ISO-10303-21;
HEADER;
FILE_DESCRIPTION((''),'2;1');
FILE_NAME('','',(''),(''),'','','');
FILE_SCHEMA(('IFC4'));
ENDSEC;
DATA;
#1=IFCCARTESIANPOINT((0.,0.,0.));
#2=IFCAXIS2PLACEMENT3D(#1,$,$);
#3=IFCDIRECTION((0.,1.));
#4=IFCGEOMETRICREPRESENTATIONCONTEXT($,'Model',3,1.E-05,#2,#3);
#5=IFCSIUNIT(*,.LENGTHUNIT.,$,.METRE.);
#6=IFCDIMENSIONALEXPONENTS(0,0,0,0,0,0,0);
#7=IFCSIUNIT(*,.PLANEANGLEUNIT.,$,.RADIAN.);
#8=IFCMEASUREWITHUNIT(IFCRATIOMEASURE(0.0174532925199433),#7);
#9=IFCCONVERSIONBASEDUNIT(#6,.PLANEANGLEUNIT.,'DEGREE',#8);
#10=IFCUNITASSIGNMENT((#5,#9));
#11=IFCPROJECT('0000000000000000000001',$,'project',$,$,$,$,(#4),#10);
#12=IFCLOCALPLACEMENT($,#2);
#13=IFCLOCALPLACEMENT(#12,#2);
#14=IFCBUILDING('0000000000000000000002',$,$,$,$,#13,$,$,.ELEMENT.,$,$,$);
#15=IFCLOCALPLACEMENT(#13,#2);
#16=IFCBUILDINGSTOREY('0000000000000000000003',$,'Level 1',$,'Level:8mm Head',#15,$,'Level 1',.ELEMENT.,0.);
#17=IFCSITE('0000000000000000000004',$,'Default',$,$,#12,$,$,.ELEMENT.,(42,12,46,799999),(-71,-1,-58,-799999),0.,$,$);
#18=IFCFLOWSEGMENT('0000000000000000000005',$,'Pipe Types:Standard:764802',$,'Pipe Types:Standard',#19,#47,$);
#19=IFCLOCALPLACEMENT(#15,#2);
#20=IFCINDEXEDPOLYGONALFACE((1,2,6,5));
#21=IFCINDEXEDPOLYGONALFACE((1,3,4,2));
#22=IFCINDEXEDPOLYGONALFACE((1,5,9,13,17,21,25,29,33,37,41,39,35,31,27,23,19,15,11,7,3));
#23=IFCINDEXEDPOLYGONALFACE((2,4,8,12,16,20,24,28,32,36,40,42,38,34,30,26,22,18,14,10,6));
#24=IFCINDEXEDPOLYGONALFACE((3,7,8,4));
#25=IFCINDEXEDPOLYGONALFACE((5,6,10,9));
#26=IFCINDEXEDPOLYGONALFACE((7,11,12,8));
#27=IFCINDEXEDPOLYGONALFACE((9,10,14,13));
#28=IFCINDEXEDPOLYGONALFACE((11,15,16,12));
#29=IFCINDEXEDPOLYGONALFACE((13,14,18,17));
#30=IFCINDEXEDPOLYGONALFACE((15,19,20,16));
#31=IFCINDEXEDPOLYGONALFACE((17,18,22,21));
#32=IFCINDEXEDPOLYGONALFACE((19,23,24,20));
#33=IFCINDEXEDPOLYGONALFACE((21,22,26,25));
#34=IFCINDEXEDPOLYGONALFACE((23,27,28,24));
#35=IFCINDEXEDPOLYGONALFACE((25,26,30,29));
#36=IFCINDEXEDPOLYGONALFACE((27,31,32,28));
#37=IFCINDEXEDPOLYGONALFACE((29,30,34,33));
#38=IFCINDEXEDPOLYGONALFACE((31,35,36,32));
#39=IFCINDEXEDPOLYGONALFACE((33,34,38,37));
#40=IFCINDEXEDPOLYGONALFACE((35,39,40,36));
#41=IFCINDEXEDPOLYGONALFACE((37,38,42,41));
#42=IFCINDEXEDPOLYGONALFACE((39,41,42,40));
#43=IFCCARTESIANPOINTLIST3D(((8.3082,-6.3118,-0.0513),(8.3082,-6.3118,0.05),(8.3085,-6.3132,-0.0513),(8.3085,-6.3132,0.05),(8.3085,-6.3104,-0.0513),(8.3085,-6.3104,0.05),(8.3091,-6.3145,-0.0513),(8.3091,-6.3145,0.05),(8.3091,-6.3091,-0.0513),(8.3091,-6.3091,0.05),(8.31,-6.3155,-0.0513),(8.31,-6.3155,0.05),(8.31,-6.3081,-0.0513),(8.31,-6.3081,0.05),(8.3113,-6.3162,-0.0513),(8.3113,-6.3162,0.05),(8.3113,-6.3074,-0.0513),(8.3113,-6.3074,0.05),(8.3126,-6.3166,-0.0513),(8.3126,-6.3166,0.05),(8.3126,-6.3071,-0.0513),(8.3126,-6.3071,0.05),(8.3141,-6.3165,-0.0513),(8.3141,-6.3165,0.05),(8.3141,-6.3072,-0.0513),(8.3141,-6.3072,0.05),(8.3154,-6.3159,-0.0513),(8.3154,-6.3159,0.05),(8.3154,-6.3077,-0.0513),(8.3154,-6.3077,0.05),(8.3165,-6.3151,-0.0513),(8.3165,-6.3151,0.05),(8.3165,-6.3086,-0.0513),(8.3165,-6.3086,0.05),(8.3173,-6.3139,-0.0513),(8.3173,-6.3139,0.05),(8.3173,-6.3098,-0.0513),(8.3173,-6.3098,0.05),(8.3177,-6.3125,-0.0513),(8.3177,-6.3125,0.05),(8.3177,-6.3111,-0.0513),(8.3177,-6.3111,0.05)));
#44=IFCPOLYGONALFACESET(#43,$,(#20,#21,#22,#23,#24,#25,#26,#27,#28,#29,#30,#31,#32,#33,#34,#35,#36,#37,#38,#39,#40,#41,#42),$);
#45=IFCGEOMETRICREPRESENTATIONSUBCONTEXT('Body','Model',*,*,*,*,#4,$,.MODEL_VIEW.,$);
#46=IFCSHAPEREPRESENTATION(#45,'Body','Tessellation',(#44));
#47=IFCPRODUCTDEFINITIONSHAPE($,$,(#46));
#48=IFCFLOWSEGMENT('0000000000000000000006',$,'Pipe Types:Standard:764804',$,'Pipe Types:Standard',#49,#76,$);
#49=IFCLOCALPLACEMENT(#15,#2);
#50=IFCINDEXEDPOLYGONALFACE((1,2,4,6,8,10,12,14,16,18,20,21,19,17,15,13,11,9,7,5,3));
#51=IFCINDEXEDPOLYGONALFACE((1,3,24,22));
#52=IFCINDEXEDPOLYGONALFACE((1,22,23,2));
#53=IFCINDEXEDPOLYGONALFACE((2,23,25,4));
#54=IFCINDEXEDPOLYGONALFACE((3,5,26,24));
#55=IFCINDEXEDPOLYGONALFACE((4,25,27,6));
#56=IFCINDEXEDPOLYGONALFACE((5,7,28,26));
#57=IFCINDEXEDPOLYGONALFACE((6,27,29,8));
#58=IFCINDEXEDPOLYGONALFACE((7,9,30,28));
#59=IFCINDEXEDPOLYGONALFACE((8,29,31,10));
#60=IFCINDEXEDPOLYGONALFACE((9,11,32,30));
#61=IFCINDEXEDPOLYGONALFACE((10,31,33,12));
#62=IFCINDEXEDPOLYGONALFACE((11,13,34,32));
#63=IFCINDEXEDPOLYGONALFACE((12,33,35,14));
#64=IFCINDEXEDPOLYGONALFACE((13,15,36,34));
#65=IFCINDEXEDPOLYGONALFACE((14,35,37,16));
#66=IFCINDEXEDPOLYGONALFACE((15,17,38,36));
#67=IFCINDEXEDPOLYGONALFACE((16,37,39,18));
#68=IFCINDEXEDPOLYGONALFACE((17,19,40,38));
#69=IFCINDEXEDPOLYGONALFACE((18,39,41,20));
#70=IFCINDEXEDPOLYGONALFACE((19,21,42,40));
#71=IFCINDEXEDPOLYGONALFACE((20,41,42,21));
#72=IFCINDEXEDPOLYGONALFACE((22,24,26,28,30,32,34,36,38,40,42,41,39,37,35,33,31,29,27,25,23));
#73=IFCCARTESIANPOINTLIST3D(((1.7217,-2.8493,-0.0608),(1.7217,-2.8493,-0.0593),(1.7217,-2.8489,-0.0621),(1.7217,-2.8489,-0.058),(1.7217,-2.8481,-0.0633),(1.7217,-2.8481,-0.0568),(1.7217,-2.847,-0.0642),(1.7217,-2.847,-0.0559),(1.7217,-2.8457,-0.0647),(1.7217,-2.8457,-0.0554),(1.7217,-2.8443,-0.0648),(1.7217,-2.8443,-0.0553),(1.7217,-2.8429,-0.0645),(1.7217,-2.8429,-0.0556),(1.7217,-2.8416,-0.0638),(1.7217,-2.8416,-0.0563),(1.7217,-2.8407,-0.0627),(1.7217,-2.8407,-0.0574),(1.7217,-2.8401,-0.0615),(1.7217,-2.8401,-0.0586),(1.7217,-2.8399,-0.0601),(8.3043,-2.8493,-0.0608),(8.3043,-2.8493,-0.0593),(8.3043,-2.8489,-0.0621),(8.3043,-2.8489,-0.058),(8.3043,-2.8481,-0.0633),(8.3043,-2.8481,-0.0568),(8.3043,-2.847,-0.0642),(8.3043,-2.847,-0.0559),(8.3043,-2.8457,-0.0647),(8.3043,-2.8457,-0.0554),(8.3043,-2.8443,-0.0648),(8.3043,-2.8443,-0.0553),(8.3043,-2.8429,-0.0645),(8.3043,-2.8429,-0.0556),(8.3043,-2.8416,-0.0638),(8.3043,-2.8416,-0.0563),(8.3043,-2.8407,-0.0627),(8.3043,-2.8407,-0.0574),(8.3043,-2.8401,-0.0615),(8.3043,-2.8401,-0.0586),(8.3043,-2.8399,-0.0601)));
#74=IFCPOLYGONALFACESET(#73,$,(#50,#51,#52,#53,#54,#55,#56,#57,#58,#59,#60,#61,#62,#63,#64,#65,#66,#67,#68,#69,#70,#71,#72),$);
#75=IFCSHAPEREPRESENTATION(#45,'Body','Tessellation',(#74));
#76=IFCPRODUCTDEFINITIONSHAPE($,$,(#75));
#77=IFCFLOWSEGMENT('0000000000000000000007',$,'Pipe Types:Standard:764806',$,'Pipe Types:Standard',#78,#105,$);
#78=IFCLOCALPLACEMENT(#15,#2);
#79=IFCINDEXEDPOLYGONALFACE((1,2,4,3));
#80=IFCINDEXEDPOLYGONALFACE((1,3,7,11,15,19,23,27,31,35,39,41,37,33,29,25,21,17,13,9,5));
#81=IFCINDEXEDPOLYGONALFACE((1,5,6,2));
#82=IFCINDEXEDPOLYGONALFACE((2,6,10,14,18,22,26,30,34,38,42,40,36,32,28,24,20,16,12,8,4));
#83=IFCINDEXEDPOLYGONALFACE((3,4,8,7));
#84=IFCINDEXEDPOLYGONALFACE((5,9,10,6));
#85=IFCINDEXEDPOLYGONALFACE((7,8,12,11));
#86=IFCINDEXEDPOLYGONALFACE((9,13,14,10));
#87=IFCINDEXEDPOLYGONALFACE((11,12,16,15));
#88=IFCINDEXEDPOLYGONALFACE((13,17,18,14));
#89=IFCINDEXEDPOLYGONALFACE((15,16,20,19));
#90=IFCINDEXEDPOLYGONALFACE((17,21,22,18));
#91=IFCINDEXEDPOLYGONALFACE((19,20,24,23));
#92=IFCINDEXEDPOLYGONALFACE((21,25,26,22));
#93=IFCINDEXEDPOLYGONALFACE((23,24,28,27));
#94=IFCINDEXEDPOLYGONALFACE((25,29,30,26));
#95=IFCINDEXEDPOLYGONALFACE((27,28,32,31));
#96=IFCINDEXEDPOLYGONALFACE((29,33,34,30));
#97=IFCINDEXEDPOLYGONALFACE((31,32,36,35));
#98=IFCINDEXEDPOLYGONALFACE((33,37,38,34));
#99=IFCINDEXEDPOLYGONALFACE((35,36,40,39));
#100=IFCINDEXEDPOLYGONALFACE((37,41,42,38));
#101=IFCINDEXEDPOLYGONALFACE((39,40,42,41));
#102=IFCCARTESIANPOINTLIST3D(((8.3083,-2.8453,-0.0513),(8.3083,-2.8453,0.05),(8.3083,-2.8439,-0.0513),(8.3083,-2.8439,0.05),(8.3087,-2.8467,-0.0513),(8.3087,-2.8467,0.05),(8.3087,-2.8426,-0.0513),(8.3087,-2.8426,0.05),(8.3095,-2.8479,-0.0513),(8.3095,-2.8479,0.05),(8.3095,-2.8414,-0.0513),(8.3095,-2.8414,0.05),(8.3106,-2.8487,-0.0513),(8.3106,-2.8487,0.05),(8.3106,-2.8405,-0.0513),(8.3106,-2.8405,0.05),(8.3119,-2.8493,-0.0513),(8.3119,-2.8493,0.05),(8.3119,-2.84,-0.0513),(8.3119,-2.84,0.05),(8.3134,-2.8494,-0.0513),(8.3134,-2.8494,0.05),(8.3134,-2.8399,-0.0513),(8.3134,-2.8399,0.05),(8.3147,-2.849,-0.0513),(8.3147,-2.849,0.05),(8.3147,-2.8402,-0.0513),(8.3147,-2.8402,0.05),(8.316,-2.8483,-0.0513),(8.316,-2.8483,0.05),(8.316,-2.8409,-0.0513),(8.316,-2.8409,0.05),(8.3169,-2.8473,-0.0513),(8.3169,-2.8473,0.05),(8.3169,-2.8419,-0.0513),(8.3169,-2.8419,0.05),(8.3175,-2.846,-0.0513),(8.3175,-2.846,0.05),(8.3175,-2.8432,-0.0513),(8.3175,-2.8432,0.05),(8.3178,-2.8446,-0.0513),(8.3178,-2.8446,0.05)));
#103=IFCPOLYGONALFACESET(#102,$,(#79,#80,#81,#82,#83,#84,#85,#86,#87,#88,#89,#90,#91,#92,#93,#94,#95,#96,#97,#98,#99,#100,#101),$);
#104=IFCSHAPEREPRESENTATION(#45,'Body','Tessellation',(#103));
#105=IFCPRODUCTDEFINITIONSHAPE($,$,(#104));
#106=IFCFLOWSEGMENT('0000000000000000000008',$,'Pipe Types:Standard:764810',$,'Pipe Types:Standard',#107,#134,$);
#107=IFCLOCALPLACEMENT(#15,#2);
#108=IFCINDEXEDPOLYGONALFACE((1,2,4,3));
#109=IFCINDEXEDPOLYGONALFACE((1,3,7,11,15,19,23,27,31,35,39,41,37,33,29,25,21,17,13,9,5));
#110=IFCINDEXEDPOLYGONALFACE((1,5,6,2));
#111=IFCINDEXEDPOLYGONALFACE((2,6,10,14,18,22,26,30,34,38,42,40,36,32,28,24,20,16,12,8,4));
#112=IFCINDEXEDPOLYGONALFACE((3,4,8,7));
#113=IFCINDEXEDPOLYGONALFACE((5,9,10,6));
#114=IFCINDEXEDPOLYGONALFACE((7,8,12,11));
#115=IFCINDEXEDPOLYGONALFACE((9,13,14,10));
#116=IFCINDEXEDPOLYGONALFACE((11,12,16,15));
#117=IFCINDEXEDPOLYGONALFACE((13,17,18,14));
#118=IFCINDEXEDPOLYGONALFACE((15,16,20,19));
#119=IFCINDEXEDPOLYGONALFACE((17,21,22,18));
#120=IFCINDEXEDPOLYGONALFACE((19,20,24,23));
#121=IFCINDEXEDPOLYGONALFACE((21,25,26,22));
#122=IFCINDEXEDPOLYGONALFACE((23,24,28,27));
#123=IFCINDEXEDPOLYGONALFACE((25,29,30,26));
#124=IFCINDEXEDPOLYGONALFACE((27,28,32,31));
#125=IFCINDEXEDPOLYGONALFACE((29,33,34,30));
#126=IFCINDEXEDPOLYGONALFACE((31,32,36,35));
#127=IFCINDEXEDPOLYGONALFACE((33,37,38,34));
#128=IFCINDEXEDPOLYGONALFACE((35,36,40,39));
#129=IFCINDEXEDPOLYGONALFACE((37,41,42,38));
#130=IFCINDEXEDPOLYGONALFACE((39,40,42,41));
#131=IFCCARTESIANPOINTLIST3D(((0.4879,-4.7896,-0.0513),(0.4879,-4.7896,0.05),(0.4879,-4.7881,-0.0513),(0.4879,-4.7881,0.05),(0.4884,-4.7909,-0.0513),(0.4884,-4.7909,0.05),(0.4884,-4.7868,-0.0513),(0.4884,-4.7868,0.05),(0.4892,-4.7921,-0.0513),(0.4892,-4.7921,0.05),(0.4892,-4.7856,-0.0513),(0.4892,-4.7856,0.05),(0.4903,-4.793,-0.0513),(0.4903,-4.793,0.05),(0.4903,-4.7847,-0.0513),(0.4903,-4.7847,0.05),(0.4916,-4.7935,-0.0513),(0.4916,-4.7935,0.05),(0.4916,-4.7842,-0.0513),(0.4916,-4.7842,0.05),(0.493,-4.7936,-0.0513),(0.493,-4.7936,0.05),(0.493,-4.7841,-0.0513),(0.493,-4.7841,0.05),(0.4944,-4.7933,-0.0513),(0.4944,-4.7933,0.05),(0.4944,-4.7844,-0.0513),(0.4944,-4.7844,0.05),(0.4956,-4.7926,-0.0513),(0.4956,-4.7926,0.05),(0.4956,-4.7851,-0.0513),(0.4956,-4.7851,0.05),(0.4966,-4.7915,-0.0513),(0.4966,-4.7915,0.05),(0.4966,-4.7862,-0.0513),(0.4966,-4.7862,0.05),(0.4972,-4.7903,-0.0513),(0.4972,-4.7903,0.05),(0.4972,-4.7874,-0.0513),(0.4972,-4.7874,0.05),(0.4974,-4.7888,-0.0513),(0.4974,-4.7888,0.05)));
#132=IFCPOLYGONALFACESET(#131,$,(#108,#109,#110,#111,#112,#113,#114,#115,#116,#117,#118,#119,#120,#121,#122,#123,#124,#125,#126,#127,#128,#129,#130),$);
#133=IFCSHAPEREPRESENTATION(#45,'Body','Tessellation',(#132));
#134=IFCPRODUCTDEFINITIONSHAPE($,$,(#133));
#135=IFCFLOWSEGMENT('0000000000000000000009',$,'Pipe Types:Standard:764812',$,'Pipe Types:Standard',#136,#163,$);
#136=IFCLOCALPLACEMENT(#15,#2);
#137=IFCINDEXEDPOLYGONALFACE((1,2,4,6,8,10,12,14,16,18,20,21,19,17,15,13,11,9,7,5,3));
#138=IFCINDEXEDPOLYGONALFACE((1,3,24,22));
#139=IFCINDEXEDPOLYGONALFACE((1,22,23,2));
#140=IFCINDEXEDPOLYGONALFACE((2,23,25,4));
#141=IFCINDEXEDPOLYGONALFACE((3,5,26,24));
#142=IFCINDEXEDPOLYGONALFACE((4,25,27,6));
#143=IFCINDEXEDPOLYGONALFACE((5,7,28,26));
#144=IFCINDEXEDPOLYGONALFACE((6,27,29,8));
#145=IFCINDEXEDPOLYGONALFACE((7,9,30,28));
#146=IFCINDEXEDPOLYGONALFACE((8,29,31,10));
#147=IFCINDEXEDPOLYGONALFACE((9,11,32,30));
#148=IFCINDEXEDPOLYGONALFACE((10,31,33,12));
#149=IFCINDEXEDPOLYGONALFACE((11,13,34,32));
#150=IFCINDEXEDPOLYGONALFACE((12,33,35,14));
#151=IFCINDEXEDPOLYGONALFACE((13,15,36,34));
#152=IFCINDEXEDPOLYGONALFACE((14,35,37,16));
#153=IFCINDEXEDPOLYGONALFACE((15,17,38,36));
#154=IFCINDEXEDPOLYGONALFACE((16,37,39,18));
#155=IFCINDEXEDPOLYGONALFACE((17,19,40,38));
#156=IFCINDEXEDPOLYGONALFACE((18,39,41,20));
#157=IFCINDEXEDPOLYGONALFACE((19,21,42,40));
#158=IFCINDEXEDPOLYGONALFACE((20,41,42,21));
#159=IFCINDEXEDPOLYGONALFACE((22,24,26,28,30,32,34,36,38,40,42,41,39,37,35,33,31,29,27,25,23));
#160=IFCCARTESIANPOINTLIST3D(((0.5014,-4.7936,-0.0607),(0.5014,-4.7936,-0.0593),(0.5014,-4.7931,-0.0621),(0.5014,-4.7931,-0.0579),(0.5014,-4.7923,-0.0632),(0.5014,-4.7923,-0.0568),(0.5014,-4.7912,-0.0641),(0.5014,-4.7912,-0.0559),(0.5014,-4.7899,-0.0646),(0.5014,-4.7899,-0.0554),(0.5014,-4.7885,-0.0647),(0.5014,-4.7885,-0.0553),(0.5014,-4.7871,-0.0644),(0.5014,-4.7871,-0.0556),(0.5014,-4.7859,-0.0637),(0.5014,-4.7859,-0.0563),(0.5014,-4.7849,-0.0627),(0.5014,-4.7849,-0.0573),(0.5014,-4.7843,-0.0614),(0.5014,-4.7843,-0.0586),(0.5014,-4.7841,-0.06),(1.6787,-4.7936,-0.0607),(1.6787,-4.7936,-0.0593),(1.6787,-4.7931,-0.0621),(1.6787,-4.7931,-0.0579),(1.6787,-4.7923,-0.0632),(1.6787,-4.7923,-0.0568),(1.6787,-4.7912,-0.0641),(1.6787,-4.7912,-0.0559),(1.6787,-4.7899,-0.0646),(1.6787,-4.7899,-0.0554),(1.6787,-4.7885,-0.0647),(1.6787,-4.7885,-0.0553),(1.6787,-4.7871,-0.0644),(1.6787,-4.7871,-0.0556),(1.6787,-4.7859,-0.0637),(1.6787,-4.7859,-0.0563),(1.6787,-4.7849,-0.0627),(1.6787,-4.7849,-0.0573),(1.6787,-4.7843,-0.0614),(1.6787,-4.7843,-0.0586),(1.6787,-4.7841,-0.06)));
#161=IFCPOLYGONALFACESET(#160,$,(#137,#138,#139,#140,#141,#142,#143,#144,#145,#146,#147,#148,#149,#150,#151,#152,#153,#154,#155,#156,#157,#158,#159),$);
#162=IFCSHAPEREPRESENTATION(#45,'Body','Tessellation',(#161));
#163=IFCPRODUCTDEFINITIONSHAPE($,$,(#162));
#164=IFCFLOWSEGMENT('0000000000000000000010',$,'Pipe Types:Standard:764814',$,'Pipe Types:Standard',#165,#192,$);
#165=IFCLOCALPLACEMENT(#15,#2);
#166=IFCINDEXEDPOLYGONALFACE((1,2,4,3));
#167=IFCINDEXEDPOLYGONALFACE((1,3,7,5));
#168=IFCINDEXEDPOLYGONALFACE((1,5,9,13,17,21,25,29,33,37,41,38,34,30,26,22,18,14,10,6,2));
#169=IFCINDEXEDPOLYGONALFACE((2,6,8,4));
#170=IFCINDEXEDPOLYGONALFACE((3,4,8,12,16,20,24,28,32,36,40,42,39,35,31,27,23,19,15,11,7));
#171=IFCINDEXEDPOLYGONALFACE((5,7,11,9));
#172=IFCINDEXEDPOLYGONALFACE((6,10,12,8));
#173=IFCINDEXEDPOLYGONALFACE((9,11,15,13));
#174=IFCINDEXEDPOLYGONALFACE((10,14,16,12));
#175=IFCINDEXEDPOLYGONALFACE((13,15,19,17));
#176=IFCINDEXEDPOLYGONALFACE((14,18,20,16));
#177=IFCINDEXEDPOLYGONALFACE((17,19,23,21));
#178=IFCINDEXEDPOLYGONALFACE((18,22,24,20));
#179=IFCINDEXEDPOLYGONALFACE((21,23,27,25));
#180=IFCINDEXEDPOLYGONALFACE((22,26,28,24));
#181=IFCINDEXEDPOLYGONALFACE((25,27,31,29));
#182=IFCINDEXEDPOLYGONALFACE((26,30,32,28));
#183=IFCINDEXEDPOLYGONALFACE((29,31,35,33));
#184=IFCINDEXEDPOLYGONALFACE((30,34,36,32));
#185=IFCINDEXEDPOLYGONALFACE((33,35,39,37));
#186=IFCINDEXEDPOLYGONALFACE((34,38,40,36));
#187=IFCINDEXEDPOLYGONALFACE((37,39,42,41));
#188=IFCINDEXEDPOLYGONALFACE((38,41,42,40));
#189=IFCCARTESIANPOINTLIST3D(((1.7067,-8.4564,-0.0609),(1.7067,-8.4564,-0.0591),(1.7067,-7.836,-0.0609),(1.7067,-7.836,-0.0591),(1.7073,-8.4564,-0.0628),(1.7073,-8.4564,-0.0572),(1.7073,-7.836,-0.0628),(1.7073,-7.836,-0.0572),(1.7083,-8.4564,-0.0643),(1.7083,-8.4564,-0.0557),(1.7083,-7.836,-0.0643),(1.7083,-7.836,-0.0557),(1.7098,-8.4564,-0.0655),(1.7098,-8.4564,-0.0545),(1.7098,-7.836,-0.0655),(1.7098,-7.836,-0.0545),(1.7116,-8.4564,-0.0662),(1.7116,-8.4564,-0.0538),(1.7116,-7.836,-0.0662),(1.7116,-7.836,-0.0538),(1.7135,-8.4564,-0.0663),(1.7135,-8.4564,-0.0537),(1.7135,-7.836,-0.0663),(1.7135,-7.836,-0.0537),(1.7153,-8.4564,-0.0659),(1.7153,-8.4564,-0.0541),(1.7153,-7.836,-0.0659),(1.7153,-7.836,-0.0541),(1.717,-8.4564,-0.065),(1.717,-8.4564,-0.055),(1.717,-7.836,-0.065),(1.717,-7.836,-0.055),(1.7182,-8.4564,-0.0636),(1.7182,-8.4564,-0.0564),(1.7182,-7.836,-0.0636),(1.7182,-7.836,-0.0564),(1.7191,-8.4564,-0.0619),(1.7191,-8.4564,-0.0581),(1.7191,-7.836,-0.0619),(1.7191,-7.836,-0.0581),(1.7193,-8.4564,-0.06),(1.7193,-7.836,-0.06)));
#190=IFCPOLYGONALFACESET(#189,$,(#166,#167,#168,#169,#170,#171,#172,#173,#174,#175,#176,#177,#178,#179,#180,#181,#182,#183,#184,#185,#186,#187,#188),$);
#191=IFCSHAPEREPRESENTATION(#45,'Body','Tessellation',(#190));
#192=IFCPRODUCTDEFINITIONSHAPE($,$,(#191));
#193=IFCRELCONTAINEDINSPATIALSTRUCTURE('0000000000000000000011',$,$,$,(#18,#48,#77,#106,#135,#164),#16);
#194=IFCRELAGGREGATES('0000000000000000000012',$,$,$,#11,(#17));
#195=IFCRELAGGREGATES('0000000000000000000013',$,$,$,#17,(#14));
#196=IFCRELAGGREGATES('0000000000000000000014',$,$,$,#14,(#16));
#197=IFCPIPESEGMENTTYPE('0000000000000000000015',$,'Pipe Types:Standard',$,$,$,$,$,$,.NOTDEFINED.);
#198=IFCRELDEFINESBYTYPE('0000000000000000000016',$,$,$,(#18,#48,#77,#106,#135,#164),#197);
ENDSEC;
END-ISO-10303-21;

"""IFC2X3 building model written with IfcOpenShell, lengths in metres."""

from ifc_helpers import new_model, entity, si_unit, converted_unit, direction, frame, frame_2d, origin, origin_2d_with_axis, place, context, subcontext, project, spatial, circle, extrude, type_object, element, save


model = new_model("IFC2X3")

# Units and contexts
model_context = context("Model", 3, precision=1e-05, world=origin(), true_north=direction((0.0, 1.0)))
body_context = subcontext(model_context, "Body", "Model", "MODEL_VIEW")
ifc_project = project(units=[si_unit("LENGTHUNIT", "METRE"), converted_unit("PLANEANGLEUNIT", "DEGREE", entity("IfcRatioMeasure", 0.0174532925199433), si_unit("PLANEANGLEUNIT", "RADIAN"), dimensions=[0, 0, 0, 0, 0, 0, 0])], contexts=[model_context])

# Site, building, storey
site_placement = place(None, origin())
site = spatial("IfcSite", under=ifc_project, at=site_placement, Name="Default", CompositionType="ELEMENT", RefLatitude=(42, 12, 46, 799999), RefLongitude=(-71, -1, -58, -799999), RefElevation=0.0)
building_placement = place(site_placement, origin())
building = spatial("IfcBuilding", under=site, at=building_placement, CompositionType="ELEMENT")
storey_placement = place(building_placement, origin())
storey = spatial("IfcBuildingStorey", under=building, at=storey_placement, Name="Level 1", ObjectType="Level:8mm Head", LongName="Level 1", CompositionType="ELEMENT", Elevation=0.0)

# Flow segments
pipe_segment_type = type_object("IfcPipeSegmentType", Name="Pipe Types:Standard", PredefinedType="NOTDEFINED")
flow_segment_1_placement = place(storey_placement, origin())
element("IfcFlowSegment", 1, at=flow_segment_1_placement, inside=storey, type_object=pipe_segment_type, Name="Pipe Types:Standard:764802", ObjectType="Pipe Types:Standard", context=body_context, shape_type="SweptSolid", body=[
    extrude(circle(Radius=0.0048, at=origin_2d_with_axis()), frame((8.313, -6.3118, -0.0513), z_axis=(0.0, 0.0, 1.0), x_axis=(-1.0, 0.0, 0.0)), (0.0, 0.0, 1.0), 0.1013),
])
flow_segment_2_placement = place(storey_placement, origin())
element("IfcFlowSegment", 2, at=flow_segment_2_placement, inside=storey, type_object=pipe_segment_type, Name="Pipe Types:Standard:764804", ObjectType="Pipe Types:Standard", context=body_context, shape_type="SweptSolid", body=[
    extrude(circle(Radius=0.0048, at=frame_2d((0.0, 0.0), x_axis=(1.0, 0.0))), frame((1.7217, -2.8446, -0.0601), z_axis=(1.0, 0.0, 0.0), x_axis=(0.0, 1.0, 0.0)), (0.0, 0.0, 1.0), 6.5826),
])
flow_segment_3_placement = place(storey_placement, origin())
element("IfcFlowSegment", 3, at=flow_segment_3_placement, inside=storey, type_object=pipe_segment_type, Name="Pipe Types:Standard:764806", ObjectType="Pipe Types:Standard", context=body_context, shape_type="SweptSolid", body=[
    extrude(circle(Radius=0.0048, at=origin_2d_with_axis()), frame((8.313, -2.8446, -0.0513)), (0.0, 0.0, 1.0), 0.1013),
])
flow_segment_4_placement = place(storey_placement, origin())
element("IfcFlowSegment", 4, at=flow_segment_4_placement, inside=storey, type_object=pipe_segment_type, Name="Pipe Types:Standard:764810", ObjectType="Pipe Types:Standard", context=body_context, shape_type="SweptSolid", body=[
    extrude(circle(Radius=0.0048, at=origin_2d_with_axis()), frame((0.4926, -4.7888, -0.0513)), (0.0, 0.0, 1.0), 0.1013),
])
flow_segment_5_placement = place(storey_placement, origin())
element("IfcFlowSegment", 5, at=flow_segment_5_placement, inside=storey, type_object=pipe_segment_type, Name="Pipe Types:Standard:764812", ObjectType="Pipe Types:Standard", context=body_context, shape_type="SweptSolid", body=[
    extrude(circle(Radius=0.0048, at=frame_2d((0.0, 0.0), x_axis=(1.0, 0.0))), frame((0.5014, -4.7888, -0.06), z_axis=(1.0, 0.0, 0.0), x_axis=(0.0, 1.0, 0.0)), (0.0, 0.0, 1.0), 1.1774),
])
flow_segment_6_placement = place(storey_placement, origin())
element("IfcFlowSegment", 6, at=flow_segment_6_placement, inside=storey, type_object=pipe_segment_type, Name="Pipe Types:Standard:764814", ObjectType="Pipe Types:Standard", context=body_context, shape_type="SweptSolid", body=[
    extrude(circle(Radius=0.0063, at=origin_2d_with_axis()), frame((1.713, -8.4564, -0.06), z_axis=(0.0, 1.0, 0.0), x_axis=(1.0, 0.0, 0.0)), (0.0, 0.0, 1.0), 0.6204),
])

save(model, "model.ifc")
